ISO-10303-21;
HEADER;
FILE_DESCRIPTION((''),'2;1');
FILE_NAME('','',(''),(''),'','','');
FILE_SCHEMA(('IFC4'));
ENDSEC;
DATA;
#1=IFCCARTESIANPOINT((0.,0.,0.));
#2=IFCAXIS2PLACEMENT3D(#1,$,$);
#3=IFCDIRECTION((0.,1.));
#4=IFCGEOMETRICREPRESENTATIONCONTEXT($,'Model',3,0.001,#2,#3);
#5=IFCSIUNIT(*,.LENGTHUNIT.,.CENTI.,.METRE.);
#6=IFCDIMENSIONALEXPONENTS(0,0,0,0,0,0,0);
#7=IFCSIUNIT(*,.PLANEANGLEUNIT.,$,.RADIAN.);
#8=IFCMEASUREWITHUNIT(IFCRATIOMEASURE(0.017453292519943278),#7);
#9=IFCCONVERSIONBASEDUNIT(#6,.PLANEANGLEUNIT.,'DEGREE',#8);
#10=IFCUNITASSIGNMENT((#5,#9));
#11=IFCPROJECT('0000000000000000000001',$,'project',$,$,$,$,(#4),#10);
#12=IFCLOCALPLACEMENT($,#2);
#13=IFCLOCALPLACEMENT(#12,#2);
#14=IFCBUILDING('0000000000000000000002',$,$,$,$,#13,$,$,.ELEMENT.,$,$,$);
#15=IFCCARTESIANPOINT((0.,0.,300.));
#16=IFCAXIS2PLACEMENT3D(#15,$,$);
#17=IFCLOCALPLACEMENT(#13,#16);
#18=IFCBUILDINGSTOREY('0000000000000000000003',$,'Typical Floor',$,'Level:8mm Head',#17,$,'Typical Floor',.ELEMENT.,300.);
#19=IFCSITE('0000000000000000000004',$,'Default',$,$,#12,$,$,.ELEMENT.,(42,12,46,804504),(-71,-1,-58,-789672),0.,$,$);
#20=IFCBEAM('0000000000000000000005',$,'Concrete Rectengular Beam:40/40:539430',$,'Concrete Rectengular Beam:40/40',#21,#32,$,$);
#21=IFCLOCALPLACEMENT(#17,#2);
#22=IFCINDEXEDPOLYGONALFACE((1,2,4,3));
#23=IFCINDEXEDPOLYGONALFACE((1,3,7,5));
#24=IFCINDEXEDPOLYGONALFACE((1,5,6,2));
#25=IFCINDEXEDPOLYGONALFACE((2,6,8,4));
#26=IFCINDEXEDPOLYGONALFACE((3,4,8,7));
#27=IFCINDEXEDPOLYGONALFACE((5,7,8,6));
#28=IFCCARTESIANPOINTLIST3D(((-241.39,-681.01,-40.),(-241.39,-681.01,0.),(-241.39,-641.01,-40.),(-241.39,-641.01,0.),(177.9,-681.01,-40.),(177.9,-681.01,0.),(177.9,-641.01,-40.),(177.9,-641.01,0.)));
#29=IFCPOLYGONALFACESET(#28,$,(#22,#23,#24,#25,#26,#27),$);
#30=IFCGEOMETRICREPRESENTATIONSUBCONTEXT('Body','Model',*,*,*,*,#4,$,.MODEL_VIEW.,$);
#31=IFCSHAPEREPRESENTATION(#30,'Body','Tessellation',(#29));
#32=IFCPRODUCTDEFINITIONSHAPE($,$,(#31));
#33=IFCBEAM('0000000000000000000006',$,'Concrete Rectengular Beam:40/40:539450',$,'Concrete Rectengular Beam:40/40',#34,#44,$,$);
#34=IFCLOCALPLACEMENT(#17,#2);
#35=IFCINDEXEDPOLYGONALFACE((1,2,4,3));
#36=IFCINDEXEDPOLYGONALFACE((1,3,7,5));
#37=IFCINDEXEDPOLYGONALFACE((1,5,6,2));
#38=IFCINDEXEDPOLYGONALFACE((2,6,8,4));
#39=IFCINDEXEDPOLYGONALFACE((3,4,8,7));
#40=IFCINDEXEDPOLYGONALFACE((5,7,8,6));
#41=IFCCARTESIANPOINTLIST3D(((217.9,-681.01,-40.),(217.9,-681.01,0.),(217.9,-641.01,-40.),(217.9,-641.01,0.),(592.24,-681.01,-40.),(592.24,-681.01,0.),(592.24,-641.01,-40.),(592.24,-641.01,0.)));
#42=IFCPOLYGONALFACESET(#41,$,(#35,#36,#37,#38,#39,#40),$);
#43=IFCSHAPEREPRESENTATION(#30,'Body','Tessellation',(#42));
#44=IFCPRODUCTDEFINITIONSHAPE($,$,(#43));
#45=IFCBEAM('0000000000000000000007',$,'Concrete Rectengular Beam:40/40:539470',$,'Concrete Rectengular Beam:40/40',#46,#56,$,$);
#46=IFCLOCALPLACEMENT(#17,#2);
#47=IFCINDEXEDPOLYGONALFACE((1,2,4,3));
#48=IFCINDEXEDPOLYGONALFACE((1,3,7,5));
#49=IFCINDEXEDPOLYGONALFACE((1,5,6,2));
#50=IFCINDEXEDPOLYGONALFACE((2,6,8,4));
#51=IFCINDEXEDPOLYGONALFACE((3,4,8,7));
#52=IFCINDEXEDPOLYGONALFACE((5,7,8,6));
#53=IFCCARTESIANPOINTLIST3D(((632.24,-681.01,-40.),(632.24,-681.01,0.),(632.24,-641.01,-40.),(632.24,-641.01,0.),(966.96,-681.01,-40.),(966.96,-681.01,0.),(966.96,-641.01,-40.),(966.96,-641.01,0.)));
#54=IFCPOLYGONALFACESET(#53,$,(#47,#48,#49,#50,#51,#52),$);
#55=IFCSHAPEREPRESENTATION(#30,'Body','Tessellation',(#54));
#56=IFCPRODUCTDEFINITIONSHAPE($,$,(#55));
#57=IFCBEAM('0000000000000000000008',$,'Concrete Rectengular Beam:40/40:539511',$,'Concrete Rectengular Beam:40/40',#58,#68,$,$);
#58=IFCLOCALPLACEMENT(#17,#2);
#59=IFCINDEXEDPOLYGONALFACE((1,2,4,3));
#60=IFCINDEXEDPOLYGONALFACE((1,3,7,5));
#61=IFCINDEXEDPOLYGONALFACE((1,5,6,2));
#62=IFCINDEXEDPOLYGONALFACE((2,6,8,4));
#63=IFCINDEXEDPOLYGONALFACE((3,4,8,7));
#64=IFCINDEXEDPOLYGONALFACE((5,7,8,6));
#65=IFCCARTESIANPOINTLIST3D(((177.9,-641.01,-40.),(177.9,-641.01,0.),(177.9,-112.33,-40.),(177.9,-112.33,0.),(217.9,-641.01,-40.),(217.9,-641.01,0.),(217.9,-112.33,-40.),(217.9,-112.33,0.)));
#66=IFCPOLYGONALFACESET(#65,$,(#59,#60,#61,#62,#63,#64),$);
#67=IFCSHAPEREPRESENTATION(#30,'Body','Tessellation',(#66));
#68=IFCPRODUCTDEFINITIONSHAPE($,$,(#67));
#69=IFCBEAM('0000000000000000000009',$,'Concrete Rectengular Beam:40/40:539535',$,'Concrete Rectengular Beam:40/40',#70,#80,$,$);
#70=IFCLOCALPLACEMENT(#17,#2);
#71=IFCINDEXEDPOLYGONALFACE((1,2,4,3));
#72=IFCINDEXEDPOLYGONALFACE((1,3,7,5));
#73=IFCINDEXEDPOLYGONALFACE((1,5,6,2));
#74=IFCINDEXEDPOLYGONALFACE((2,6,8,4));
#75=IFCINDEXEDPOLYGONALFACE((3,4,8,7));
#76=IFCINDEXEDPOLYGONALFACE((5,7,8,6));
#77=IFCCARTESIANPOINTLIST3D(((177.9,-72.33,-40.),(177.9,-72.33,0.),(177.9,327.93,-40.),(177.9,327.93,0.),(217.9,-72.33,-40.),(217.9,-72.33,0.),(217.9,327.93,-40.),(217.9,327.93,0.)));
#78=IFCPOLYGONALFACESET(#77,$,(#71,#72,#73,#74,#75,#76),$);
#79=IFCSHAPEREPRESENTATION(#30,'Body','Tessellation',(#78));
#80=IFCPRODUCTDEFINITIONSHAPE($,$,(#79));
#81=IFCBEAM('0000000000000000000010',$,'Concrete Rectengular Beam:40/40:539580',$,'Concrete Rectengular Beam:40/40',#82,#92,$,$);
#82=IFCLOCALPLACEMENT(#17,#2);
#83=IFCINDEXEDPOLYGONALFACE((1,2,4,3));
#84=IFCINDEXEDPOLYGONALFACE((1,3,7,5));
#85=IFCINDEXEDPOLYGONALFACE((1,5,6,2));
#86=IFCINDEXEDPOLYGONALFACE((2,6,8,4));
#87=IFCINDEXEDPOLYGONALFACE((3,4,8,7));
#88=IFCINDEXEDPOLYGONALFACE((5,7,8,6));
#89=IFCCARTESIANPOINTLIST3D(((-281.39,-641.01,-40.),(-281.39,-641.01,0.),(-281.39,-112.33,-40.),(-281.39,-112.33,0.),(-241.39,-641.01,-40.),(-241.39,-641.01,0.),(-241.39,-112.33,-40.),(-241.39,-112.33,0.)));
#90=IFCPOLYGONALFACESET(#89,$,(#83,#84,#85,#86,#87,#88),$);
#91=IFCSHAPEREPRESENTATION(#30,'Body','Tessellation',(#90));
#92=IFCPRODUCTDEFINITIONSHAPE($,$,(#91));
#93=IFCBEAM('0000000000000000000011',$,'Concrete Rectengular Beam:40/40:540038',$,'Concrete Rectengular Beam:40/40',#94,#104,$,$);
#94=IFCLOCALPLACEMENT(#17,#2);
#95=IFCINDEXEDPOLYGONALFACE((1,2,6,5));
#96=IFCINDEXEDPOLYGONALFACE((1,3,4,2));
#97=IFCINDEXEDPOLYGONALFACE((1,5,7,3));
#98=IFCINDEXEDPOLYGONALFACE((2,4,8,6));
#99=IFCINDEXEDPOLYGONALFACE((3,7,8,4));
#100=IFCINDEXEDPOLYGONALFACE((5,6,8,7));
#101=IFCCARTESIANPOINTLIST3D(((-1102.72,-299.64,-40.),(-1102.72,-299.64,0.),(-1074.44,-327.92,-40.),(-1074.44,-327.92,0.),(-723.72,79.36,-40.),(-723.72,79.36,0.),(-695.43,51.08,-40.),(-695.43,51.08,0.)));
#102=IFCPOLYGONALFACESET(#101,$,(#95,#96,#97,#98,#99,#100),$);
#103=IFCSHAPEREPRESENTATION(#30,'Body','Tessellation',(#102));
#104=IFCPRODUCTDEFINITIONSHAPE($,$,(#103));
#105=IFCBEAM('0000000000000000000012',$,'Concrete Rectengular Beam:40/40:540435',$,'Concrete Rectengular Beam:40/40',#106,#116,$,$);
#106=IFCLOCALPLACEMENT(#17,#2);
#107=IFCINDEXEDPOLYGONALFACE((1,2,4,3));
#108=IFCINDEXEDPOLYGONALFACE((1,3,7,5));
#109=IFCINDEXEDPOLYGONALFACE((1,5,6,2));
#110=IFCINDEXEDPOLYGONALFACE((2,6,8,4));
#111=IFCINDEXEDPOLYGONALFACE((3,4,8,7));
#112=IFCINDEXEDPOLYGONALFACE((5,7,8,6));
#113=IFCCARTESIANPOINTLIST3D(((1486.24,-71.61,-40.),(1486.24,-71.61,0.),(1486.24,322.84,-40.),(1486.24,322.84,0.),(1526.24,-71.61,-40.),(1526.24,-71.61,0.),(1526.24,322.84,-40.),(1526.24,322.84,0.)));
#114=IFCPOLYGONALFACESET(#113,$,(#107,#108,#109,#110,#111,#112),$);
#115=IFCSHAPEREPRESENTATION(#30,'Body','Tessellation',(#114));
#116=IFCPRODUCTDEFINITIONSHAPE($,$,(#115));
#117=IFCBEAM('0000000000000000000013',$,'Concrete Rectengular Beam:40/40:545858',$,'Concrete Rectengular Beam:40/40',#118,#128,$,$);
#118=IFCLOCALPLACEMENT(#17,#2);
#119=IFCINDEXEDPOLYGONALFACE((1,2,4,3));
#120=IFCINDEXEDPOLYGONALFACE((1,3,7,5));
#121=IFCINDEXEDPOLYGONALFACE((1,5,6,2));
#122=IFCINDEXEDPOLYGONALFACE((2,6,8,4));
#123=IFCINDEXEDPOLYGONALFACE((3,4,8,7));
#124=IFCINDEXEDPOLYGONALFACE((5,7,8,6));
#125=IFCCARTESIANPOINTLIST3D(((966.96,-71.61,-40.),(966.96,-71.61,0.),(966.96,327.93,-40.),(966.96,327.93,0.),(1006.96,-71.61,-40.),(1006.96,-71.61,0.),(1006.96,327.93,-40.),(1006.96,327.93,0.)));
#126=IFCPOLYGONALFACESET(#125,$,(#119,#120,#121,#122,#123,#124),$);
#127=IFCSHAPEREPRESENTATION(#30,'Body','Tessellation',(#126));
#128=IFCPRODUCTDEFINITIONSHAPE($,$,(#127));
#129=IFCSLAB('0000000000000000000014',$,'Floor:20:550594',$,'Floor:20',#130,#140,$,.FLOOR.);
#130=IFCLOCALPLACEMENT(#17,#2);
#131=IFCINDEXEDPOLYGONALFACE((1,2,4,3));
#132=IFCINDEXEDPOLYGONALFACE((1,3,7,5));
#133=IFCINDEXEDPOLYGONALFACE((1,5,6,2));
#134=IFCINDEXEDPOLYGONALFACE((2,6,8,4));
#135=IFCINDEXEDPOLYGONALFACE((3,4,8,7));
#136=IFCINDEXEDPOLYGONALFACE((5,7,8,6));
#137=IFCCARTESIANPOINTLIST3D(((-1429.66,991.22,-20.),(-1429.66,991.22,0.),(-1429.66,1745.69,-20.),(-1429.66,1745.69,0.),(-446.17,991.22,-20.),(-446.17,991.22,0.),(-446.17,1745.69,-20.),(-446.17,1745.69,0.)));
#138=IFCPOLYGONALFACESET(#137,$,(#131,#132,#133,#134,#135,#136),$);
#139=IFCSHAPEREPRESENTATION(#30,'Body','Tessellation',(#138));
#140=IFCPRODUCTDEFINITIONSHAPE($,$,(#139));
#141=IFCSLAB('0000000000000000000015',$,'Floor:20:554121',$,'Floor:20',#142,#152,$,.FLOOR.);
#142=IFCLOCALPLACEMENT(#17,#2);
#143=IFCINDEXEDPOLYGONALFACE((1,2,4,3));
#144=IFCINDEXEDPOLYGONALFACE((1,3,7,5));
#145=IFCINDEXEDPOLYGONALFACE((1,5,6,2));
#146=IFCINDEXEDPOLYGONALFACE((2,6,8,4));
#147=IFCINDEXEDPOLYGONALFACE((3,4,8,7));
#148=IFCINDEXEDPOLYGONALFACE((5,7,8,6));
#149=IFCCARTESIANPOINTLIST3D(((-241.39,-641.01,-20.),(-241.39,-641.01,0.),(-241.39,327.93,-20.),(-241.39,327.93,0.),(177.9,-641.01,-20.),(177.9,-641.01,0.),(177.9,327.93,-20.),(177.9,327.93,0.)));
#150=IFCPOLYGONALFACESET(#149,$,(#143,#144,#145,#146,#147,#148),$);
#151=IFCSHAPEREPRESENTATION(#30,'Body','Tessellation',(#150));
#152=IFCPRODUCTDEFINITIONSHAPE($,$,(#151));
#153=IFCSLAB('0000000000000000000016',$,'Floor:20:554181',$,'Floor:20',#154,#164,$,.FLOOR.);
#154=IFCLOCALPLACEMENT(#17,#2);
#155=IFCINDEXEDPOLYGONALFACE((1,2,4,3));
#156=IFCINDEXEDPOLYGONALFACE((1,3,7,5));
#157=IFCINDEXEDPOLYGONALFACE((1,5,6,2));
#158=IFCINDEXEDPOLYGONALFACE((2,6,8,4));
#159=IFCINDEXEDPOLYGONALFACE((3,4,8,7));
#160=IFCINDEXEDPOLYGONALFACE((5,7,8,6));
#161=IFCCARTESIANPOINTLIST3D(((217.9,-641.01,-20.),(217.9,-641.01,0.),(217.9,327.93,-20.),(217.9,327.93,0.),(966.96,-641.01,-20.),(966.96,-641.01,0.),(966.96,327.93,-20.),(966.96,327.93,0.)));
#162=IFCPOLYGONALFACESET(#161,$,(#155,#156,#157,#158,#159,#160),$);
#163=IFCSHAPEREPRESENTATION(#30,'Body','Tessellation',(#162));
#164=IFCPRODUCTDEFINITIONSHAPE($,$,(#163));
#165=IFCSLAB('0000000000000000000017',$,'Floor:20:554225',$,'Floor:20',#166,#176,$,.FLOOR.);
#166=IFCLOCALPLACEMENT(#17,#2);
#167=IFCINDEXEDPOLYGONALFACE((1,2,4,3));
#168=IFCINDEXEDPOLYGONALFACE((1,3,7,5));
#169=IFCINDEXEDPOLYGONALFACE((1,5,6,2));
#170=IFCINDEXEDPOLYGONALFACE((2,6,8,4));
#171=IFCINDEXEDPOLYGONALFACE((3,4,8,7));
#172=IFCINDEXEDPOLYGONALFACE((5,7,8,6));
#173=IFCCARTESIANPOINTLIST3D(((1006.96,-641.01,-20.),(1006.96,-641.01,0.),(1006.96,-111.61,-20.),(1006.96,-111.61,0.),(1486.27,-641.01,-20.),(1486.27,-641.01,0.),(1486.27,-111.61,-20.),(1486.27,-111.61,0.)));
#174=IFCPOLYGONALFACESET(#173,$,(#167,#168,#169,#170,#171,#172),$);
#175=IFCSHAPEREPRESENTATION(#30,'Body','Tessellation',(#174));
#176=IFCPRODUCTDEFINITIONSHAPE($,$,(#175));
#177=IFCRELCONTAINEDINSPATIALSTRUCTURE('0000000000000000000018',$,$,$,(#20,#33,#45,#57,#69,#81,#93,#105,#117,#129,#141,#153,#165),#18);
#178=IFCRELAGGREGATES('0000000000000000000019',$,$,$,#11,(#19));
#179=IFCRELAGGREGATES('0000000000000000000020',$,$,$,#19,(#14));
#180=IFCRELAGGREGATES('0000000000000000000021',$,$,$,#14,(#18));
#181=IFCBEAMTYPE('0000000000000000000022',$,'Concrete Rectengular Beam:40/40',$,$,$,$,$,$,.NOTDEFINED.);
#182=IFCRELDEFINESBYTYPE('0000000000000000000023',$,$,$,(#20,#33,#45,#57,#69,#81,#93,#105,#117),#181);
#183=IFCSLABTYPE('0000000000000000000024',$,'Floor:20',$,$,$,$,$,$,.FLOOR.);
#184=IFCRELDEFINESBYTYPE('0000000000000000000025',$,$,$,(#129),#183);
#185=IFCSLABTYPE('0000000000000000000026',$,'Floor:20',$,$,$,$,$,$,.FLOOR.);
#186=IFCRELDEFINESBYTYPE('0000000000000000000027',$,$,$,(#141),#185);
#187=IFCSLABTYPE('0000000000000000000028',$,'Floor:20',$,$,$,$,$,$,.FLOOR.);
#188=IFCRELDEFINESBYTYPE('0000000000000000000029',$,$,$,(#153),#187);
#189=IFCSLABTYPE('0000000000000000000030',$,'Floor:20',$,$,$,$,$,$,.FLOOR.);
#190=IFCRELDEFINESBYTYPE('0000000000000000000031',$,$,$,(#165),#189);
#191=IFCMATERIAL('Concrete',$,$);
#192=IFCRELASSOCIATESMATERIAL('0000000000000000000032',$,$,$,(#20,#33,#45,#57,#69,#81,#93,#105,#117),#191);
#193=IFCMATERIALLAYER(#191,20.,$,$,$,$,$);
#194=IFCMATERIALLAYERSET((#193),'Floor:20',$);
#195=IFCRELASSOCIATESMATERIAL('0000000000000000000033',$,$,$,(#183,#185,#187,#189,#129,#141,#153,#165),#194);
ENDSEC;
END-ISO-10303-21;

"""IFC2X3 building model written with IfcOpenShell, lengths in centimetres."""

from ifc_helpers import new_model, entity, si_unit, converted_unit, direction, frame, frame_2d, origin, origin_2d_with_axis, place, context, subcontext, project, spatial, rectangle, extrude, material, layer, layer_set, layer_usage, type_object, element, save


model = new_model("IFC2X3")

# Units and contexts
model_context = context("Model", 3, precision=0.001, world=origin(), true_north=direction((0.0, 1.0)))
body_context = subcontext(model_context, "Body", "Model", "MODEL_VIEW")
ifc_project = project(units=[si_unit("LENGTHUNIT", "METRE", prefix="CENTI"), converted_unit("PLANEANGLEUNIT", "DEGREE", entity("IfcRatioMeasure", 0.017453292519943278), si_unit("PLANEANGLEUNIT", "RADIAN"), dimensions=[0, 0, 0, 0, 0, 0, 0])], contexts=[model_context])

# Site, building, storey
site_placement = place(None, origin())
site = spatial("IfcSite", under=ifc_project, at=site_placement, Name="Default", CompositionType="ELEMENT", RefLatitude=(42, 12, 46, 804504), RefLongitude=(-71, -1, -58, -789672), RefElevation=0.0)
building_placement = place(site_placement, origin())
building = spatial("IfcBuilding", under=site, at=building_placement, CompositionType="ELEMENT")
storey_placement = place(building_placement, frame((0.0, 0.0, 300.0)))
storey = spatial("IfcBuildingStorey", under=building, at=storey_placement, Name="Typical Floor", ObjectType="Level:8mm Head", LongName="Typical Floor", CompositionType="ELEMENT", Elevation=300.0)

# Beams
ifc_material = material(Name="Concrete")
beam_type_1 = type_object("IfcBeamType", Name="Concrete Rectengular Beam:40/40", PredefinedType="NOTDEFINED")
beam_1_placement = place(storey_placement, frame((-261.39, -661.01, 0.0)))
element("IfcBeam", 1, at=beam_1_placement, inside=storey, type_object=beam_type_1, material=ifc_material, Name="Concrete Rectengular Beam:40/40:539430", ObjectType="Concrete Rectengular Beam:40/40", context=body_context, shape_type="SweptSolid", body=[
    extrude(rectangle(XDim=40.0, YDim=40.0, at=frame_2d((0.0, 0.0), x_axis=(1.0, 0.0))), frame((20.0, 0.0, -20.0), z_axis=(1.0, 0.0, 0.0), x_axis=(0.0, 0.0, -1.0)), (0.0, 0.0, 1.0), 419.29),
])
beam_2_placement = place(storey_placement, frame((197.9, -661.01, 0.0)))
element("IfcBeam", 2, at=beam_2_placement, inside=storey, type_object=beam_type_1, material=ifc_material, Name="Concrete Rectengular Beam:40/40:539450", ObjectType="Concrete Rectengular Beam:40/40", context=body_context, shape_type="SweptSolid", body=[
    extrude(rectangle(XDim=40.0, YDim=40.0, at=frame_2d((0.0, 0.0), x_axis=(1.0, 0.0))), frame((20.0, 0.0, -20.0), z_axis=(1.0, 0.0, 0.0), x_axis=(0.0, 0.0, -1.0)), (0.0, 0.0, 1.0), 374.34),
])
beam_3_placement = place(storey_placement, frame((612.24, -661.01, 0.0)))
element("IfcBeam", 3, at=beam_3_placement, inside=storey, type_object=beam_type_1, material=ifc_material, Name="Concrete Rectengular Beam:40/40:539470", ObjectType="Concrete Rectengular Beam:40/40", context=body_context, shape_type="SweptSolid", body=[
    extrude(rectangle(XDim=40.0, YDim=40.0, at=frame_2d((0.0, 0.0), x_axis=(1.0, 0.0))), frame((20.0, 0.0, -20.0), z_axis=(1.0, 0.0, 0.0), x_axis=(0.0, 0.0, -1.0)), (0.0, 0.0, 1.0), 334.72),
])
beam_4_placement = place(storey_placement, frame((197.9, -661.01, 0.0), z_axis=(0.0, 0.0, 1.0), x_axis=(0.0, 1.0, 0.0)))
element("IfcBeam", 4, at=beam_4_placement, inside=storey, type_object=beam_type_1, material=ifc_material, Name="Concrete Rectengular Beam:40/40:539511", ObjectType="Concrete Rectengular Beam:40/40", context=body_context, shape_type="SweptSolid", body=[
    extrude(rectangle(XDim=40.0, YDim=40.0, at=frame_2d((0.0, 0.0), x_axis=(1.0, 0.0))), frame((20.0, 0.0, -20.0), z_axis=(1.0, 0.0, 0.0), x_axis=(0.0, 0.0, -1.0)), (0.0, 0.0, 1.0), 528.68),
])
beam_5_placement = place(storey_placement, frame((197.9, -92.33, 0.0), z_axis=(0.0, 0.0, 1.0), x_axis=(0.0, 1.0, 0.0)))
element("IfcBeam", 5, at=beam_5_placement, inside=storey, type_object=beam_type_1, material=ifc_material, Name="Concrete Rectengular Beam:40/40:539535", ObjectType="Concrete Rectengular Beam:40/40", context=body_context, shape_type="SweptSolid", body=[
    extrude(rectangle(XDim=40.0, YDim=40.0, at=origin_2d_with_axis()), frame((20.0, 0.0, -20.0), z_axis=(1.0, 0.0, 0.0), x_axis=(0.0, 0.0, -1.0)), (0.0, 0.0, 1.0), 400.26),
])
beam_6_placement = place(storey_placement, frame((-261.39, -661.01, 0.0), z_axis=(0.0, 0.0, 1.0), x_axis=(0.0, 1.0, 0.0)))
element("IfcBeam", 6, at=beam_6_placement, inside=storey, type_object=beam_type_1, material=ifc_material, Name="Concrete Rectengular Beam:40/40:539580", ObjectType="Concrete Rectengular Beam:40/40", context=body_context, shape_type="SweptSolid", body=[
    extrude(rectangle(XDim=40.0, YDim=40.0, at=frame_2d((0.0, 0.0), x_axis=(1.0, 0.0))), frame((20.0, 0.0, -20.0), z_axis=(1.0, 0.0, 0.0), x_axis=(0.0, 0.0, -1.0)), (0.0, 0.0, 1.0), 528.68),
])
beam_7_placement = place(storey_placement, frame((-1102.72, -327.92, 0.0), z_axis=(0.0, 0.0, 1.0), x_axis=(0.707107, 0.707107, 0.0)))
element("IfcBeam", 7, at=beam_7_placement, inside=storey, type_object=beam_type_1, material=ifc_material, Name="Concrete Rectengular Beam:40/40:540038", ObjectType="Concrete Rectengular Beam:40/40", context=body_context, shape_type="SweptSolid", body=[
    extrude(rectangle(XDim=40.0, YDim=40.0, at=origin_2d_with_axis()), frame((20.0, 0.0, -20.0), z_axis=(1.0, 0.0, 0.0), x_axis=(0.0, 0.0, -1.0)), (0.0, 0.0, 1.0), 535.99),
])
beam_8_placement = place(storey_placement, frame((1506.24, -91.61, 0.0), z_axis=(0.0, 0.0, 1.0), x_axis=(0.0, 1.0, 0.0)))
element("IfcBeam", 8, at=beam_8_placement, inside=storey, type_object=beam_type_1, material=ifc_material, Name="Concrete Rectengular Beam:40/40:540435", ObjectType="Concrete Rectengular Beam:40/40", context=body_context, shape_type="SweptSolid", body=[
    extrude(rectangle(XDim=40.0, YDim=40.0, at=frame_2d((0.0, 0.0), x_axis=(1.0, 0.0))), frame((20.0, 0.0, -20.0), z_axis=(1.0, 0.0, 0.0), x_axis=(0.0, 0.0, -1.0)), (0.0, 0.0, 1.0), 394.46),
])
beam_9_placement = place(storey_placement, frame((986.96, -91.61, 0.0), z_axis=(0.0, 0.0, 1.0), x_axis=(0.0, 1.0, 0.0)))
element("IfcBeam", 9, at=beam_9_placement, inside=storey, type_object=beam_type_1, material=ifc_material, Name="Concrete Rectengular Beam:40/40:545858", ObjectType="Concrete Rectengular Beam:40/40", context=body_context, shape_type="SweptSolid", body=[
    extrude(rectangle(XDim=40.0, YDim=40.0, at=frame_2d((0.0, 0.0), x_axis=(1.0, 0.0))), frame((20.0, 0.0, -20.0), z_axis=(1.0, 0.0, 0.0), x_axis=(0.0, 0.0, -1.0)), (0.0, 0.0, 1.0), 399.55),
])

# Slabs
ifc_layer = layer(ifc_material, 20.0)
ifc_layer_set = layer_set([ifc_layer], Name="Floor:20")
ifc_layer_usage_1 = layer_usage(ifc_layer_set, "AXIS3", "POSITIVE", 0.0)
slab_type_1 = type_object("IfcSlabType", Name="Floor:20", PredefinedType="FLOOR", material=ifc_layer_set)
slab_1_placement = place(storey_placement, origin())
element("IfcSlab", 10, at=slab_1_placement, inside=storey, type_object=slab_type_1, material=ifc_layer_usage_1, Name="Floor:20:550594", ObjectType="Floor:20", PredefinedType="FLOOR", context=body_context, shape_type="SweptSolid", body=[
    extrude(rectangle(XDim=754.47, YDim=983.49, at=frame_2d((0.0, 0.0), x_axis=(1.0, 0.0))), frame((-937.92, 1368.45, 0.0), z_axis=(0.0, 0.0, -1.0), x_axis=(0.0, 1.0, 0.0)), (0.0, 0.0, 1.0), 20.0),
])
ifc_layer_usage_2 = layer_usage(ifc_layer_set, "AXIS3", "POSITIVE", 0.0)
slab_type_2 = type_object("IfcSlabType", Name="Floor:20", PredefinedType="FLOOR", material=ifc_layer_set)
slab_2_placement = place(storey_placement, origin())
element("IfcSlab", 11, at=slab_2_placement, inside=storey, type_object=slab_type_2, material=ifc_layer_usage_2, Name="Floor:20:554121", ObjectType="Floor:20", PredefinedType="FLOOR", context=body_context, shape_type="SweptSolid", body=[
    extrude(rectangle(XDim=968.94, YDim=419.29, at=frame_2d((0.0, 0.0), x_axis=(1.0, 0.0))), frame((-31.74, -156.54, 0.0), z_axis=(0.0, 0.0, -1.0), x_axis=(0.0, 1.0, 0.0)), (0.0, 0.0, 1.0), 20.0),
])
ifc_layer_usage_3 = layer_usage(ifc_layer_set, "AXIS3", "POSITIVE", 0.0)
slab_type_3 = type_object("IfcSlabType", Name="Floor:20", PredefinedType="FLOOR", material=ifc_layer_set)
slab_3_placement = place(storey_placement, origin())
element("IfcSlab", 12, at=slab_3_placement, inside=storey, type_object=slab_type_3, material=ifc_layer_usage_3, Name="Floor:20:554181", ObjectType="Floor:20", PredefinedType="FLOOR", context=body_context, shape_type="SweptSolid", body=[
    extrude(rectangle(XDim=968.94, YDim=749.06, at=origin_2d_with_axis()), frame((592.43, -156.54, 0.0), z_axis=(0.0, 0.0, -1.0), x_axis=(0.0, 1.0, 0.0)), (0.0, 0.0, 1.0), 20.0),
])
ifc_layer_usage_4 = layer_usage(ifc_layer_set, "AXIS3", "POSITIVE", 0.0)
slab_type_4 = type_object("IfcSlabType", Name="Floor:20", PredefinedType="FLOOR", material=ifc_layer_set)
slab_4_placement = place(storey_placement, origin())
element("IfcSlab", 13, at=slab_4_placement, inside=storey, type_object=slab_type_4, material=ifc_layer_usage_4, Name="Floor:20:554225", ObjectType="Floor:20", PredefinedType="FLOOR", context=body_context, shape_type="SweptSolid", body=[
    extrude(rectangle(XDim=529.39, YDim=479.3, at=frame_2d((0.0, 0.0), x_axis=(1.0, 0.0))), frame((1246.61, -376.31, 0.0), z_axis=(0.0, 0.0, -1.0), x_axis=(0.0, 1.0, 0.0)), (0.0, 0.0, 1.0), 20.0),
])

save(model, "model.ifc")
